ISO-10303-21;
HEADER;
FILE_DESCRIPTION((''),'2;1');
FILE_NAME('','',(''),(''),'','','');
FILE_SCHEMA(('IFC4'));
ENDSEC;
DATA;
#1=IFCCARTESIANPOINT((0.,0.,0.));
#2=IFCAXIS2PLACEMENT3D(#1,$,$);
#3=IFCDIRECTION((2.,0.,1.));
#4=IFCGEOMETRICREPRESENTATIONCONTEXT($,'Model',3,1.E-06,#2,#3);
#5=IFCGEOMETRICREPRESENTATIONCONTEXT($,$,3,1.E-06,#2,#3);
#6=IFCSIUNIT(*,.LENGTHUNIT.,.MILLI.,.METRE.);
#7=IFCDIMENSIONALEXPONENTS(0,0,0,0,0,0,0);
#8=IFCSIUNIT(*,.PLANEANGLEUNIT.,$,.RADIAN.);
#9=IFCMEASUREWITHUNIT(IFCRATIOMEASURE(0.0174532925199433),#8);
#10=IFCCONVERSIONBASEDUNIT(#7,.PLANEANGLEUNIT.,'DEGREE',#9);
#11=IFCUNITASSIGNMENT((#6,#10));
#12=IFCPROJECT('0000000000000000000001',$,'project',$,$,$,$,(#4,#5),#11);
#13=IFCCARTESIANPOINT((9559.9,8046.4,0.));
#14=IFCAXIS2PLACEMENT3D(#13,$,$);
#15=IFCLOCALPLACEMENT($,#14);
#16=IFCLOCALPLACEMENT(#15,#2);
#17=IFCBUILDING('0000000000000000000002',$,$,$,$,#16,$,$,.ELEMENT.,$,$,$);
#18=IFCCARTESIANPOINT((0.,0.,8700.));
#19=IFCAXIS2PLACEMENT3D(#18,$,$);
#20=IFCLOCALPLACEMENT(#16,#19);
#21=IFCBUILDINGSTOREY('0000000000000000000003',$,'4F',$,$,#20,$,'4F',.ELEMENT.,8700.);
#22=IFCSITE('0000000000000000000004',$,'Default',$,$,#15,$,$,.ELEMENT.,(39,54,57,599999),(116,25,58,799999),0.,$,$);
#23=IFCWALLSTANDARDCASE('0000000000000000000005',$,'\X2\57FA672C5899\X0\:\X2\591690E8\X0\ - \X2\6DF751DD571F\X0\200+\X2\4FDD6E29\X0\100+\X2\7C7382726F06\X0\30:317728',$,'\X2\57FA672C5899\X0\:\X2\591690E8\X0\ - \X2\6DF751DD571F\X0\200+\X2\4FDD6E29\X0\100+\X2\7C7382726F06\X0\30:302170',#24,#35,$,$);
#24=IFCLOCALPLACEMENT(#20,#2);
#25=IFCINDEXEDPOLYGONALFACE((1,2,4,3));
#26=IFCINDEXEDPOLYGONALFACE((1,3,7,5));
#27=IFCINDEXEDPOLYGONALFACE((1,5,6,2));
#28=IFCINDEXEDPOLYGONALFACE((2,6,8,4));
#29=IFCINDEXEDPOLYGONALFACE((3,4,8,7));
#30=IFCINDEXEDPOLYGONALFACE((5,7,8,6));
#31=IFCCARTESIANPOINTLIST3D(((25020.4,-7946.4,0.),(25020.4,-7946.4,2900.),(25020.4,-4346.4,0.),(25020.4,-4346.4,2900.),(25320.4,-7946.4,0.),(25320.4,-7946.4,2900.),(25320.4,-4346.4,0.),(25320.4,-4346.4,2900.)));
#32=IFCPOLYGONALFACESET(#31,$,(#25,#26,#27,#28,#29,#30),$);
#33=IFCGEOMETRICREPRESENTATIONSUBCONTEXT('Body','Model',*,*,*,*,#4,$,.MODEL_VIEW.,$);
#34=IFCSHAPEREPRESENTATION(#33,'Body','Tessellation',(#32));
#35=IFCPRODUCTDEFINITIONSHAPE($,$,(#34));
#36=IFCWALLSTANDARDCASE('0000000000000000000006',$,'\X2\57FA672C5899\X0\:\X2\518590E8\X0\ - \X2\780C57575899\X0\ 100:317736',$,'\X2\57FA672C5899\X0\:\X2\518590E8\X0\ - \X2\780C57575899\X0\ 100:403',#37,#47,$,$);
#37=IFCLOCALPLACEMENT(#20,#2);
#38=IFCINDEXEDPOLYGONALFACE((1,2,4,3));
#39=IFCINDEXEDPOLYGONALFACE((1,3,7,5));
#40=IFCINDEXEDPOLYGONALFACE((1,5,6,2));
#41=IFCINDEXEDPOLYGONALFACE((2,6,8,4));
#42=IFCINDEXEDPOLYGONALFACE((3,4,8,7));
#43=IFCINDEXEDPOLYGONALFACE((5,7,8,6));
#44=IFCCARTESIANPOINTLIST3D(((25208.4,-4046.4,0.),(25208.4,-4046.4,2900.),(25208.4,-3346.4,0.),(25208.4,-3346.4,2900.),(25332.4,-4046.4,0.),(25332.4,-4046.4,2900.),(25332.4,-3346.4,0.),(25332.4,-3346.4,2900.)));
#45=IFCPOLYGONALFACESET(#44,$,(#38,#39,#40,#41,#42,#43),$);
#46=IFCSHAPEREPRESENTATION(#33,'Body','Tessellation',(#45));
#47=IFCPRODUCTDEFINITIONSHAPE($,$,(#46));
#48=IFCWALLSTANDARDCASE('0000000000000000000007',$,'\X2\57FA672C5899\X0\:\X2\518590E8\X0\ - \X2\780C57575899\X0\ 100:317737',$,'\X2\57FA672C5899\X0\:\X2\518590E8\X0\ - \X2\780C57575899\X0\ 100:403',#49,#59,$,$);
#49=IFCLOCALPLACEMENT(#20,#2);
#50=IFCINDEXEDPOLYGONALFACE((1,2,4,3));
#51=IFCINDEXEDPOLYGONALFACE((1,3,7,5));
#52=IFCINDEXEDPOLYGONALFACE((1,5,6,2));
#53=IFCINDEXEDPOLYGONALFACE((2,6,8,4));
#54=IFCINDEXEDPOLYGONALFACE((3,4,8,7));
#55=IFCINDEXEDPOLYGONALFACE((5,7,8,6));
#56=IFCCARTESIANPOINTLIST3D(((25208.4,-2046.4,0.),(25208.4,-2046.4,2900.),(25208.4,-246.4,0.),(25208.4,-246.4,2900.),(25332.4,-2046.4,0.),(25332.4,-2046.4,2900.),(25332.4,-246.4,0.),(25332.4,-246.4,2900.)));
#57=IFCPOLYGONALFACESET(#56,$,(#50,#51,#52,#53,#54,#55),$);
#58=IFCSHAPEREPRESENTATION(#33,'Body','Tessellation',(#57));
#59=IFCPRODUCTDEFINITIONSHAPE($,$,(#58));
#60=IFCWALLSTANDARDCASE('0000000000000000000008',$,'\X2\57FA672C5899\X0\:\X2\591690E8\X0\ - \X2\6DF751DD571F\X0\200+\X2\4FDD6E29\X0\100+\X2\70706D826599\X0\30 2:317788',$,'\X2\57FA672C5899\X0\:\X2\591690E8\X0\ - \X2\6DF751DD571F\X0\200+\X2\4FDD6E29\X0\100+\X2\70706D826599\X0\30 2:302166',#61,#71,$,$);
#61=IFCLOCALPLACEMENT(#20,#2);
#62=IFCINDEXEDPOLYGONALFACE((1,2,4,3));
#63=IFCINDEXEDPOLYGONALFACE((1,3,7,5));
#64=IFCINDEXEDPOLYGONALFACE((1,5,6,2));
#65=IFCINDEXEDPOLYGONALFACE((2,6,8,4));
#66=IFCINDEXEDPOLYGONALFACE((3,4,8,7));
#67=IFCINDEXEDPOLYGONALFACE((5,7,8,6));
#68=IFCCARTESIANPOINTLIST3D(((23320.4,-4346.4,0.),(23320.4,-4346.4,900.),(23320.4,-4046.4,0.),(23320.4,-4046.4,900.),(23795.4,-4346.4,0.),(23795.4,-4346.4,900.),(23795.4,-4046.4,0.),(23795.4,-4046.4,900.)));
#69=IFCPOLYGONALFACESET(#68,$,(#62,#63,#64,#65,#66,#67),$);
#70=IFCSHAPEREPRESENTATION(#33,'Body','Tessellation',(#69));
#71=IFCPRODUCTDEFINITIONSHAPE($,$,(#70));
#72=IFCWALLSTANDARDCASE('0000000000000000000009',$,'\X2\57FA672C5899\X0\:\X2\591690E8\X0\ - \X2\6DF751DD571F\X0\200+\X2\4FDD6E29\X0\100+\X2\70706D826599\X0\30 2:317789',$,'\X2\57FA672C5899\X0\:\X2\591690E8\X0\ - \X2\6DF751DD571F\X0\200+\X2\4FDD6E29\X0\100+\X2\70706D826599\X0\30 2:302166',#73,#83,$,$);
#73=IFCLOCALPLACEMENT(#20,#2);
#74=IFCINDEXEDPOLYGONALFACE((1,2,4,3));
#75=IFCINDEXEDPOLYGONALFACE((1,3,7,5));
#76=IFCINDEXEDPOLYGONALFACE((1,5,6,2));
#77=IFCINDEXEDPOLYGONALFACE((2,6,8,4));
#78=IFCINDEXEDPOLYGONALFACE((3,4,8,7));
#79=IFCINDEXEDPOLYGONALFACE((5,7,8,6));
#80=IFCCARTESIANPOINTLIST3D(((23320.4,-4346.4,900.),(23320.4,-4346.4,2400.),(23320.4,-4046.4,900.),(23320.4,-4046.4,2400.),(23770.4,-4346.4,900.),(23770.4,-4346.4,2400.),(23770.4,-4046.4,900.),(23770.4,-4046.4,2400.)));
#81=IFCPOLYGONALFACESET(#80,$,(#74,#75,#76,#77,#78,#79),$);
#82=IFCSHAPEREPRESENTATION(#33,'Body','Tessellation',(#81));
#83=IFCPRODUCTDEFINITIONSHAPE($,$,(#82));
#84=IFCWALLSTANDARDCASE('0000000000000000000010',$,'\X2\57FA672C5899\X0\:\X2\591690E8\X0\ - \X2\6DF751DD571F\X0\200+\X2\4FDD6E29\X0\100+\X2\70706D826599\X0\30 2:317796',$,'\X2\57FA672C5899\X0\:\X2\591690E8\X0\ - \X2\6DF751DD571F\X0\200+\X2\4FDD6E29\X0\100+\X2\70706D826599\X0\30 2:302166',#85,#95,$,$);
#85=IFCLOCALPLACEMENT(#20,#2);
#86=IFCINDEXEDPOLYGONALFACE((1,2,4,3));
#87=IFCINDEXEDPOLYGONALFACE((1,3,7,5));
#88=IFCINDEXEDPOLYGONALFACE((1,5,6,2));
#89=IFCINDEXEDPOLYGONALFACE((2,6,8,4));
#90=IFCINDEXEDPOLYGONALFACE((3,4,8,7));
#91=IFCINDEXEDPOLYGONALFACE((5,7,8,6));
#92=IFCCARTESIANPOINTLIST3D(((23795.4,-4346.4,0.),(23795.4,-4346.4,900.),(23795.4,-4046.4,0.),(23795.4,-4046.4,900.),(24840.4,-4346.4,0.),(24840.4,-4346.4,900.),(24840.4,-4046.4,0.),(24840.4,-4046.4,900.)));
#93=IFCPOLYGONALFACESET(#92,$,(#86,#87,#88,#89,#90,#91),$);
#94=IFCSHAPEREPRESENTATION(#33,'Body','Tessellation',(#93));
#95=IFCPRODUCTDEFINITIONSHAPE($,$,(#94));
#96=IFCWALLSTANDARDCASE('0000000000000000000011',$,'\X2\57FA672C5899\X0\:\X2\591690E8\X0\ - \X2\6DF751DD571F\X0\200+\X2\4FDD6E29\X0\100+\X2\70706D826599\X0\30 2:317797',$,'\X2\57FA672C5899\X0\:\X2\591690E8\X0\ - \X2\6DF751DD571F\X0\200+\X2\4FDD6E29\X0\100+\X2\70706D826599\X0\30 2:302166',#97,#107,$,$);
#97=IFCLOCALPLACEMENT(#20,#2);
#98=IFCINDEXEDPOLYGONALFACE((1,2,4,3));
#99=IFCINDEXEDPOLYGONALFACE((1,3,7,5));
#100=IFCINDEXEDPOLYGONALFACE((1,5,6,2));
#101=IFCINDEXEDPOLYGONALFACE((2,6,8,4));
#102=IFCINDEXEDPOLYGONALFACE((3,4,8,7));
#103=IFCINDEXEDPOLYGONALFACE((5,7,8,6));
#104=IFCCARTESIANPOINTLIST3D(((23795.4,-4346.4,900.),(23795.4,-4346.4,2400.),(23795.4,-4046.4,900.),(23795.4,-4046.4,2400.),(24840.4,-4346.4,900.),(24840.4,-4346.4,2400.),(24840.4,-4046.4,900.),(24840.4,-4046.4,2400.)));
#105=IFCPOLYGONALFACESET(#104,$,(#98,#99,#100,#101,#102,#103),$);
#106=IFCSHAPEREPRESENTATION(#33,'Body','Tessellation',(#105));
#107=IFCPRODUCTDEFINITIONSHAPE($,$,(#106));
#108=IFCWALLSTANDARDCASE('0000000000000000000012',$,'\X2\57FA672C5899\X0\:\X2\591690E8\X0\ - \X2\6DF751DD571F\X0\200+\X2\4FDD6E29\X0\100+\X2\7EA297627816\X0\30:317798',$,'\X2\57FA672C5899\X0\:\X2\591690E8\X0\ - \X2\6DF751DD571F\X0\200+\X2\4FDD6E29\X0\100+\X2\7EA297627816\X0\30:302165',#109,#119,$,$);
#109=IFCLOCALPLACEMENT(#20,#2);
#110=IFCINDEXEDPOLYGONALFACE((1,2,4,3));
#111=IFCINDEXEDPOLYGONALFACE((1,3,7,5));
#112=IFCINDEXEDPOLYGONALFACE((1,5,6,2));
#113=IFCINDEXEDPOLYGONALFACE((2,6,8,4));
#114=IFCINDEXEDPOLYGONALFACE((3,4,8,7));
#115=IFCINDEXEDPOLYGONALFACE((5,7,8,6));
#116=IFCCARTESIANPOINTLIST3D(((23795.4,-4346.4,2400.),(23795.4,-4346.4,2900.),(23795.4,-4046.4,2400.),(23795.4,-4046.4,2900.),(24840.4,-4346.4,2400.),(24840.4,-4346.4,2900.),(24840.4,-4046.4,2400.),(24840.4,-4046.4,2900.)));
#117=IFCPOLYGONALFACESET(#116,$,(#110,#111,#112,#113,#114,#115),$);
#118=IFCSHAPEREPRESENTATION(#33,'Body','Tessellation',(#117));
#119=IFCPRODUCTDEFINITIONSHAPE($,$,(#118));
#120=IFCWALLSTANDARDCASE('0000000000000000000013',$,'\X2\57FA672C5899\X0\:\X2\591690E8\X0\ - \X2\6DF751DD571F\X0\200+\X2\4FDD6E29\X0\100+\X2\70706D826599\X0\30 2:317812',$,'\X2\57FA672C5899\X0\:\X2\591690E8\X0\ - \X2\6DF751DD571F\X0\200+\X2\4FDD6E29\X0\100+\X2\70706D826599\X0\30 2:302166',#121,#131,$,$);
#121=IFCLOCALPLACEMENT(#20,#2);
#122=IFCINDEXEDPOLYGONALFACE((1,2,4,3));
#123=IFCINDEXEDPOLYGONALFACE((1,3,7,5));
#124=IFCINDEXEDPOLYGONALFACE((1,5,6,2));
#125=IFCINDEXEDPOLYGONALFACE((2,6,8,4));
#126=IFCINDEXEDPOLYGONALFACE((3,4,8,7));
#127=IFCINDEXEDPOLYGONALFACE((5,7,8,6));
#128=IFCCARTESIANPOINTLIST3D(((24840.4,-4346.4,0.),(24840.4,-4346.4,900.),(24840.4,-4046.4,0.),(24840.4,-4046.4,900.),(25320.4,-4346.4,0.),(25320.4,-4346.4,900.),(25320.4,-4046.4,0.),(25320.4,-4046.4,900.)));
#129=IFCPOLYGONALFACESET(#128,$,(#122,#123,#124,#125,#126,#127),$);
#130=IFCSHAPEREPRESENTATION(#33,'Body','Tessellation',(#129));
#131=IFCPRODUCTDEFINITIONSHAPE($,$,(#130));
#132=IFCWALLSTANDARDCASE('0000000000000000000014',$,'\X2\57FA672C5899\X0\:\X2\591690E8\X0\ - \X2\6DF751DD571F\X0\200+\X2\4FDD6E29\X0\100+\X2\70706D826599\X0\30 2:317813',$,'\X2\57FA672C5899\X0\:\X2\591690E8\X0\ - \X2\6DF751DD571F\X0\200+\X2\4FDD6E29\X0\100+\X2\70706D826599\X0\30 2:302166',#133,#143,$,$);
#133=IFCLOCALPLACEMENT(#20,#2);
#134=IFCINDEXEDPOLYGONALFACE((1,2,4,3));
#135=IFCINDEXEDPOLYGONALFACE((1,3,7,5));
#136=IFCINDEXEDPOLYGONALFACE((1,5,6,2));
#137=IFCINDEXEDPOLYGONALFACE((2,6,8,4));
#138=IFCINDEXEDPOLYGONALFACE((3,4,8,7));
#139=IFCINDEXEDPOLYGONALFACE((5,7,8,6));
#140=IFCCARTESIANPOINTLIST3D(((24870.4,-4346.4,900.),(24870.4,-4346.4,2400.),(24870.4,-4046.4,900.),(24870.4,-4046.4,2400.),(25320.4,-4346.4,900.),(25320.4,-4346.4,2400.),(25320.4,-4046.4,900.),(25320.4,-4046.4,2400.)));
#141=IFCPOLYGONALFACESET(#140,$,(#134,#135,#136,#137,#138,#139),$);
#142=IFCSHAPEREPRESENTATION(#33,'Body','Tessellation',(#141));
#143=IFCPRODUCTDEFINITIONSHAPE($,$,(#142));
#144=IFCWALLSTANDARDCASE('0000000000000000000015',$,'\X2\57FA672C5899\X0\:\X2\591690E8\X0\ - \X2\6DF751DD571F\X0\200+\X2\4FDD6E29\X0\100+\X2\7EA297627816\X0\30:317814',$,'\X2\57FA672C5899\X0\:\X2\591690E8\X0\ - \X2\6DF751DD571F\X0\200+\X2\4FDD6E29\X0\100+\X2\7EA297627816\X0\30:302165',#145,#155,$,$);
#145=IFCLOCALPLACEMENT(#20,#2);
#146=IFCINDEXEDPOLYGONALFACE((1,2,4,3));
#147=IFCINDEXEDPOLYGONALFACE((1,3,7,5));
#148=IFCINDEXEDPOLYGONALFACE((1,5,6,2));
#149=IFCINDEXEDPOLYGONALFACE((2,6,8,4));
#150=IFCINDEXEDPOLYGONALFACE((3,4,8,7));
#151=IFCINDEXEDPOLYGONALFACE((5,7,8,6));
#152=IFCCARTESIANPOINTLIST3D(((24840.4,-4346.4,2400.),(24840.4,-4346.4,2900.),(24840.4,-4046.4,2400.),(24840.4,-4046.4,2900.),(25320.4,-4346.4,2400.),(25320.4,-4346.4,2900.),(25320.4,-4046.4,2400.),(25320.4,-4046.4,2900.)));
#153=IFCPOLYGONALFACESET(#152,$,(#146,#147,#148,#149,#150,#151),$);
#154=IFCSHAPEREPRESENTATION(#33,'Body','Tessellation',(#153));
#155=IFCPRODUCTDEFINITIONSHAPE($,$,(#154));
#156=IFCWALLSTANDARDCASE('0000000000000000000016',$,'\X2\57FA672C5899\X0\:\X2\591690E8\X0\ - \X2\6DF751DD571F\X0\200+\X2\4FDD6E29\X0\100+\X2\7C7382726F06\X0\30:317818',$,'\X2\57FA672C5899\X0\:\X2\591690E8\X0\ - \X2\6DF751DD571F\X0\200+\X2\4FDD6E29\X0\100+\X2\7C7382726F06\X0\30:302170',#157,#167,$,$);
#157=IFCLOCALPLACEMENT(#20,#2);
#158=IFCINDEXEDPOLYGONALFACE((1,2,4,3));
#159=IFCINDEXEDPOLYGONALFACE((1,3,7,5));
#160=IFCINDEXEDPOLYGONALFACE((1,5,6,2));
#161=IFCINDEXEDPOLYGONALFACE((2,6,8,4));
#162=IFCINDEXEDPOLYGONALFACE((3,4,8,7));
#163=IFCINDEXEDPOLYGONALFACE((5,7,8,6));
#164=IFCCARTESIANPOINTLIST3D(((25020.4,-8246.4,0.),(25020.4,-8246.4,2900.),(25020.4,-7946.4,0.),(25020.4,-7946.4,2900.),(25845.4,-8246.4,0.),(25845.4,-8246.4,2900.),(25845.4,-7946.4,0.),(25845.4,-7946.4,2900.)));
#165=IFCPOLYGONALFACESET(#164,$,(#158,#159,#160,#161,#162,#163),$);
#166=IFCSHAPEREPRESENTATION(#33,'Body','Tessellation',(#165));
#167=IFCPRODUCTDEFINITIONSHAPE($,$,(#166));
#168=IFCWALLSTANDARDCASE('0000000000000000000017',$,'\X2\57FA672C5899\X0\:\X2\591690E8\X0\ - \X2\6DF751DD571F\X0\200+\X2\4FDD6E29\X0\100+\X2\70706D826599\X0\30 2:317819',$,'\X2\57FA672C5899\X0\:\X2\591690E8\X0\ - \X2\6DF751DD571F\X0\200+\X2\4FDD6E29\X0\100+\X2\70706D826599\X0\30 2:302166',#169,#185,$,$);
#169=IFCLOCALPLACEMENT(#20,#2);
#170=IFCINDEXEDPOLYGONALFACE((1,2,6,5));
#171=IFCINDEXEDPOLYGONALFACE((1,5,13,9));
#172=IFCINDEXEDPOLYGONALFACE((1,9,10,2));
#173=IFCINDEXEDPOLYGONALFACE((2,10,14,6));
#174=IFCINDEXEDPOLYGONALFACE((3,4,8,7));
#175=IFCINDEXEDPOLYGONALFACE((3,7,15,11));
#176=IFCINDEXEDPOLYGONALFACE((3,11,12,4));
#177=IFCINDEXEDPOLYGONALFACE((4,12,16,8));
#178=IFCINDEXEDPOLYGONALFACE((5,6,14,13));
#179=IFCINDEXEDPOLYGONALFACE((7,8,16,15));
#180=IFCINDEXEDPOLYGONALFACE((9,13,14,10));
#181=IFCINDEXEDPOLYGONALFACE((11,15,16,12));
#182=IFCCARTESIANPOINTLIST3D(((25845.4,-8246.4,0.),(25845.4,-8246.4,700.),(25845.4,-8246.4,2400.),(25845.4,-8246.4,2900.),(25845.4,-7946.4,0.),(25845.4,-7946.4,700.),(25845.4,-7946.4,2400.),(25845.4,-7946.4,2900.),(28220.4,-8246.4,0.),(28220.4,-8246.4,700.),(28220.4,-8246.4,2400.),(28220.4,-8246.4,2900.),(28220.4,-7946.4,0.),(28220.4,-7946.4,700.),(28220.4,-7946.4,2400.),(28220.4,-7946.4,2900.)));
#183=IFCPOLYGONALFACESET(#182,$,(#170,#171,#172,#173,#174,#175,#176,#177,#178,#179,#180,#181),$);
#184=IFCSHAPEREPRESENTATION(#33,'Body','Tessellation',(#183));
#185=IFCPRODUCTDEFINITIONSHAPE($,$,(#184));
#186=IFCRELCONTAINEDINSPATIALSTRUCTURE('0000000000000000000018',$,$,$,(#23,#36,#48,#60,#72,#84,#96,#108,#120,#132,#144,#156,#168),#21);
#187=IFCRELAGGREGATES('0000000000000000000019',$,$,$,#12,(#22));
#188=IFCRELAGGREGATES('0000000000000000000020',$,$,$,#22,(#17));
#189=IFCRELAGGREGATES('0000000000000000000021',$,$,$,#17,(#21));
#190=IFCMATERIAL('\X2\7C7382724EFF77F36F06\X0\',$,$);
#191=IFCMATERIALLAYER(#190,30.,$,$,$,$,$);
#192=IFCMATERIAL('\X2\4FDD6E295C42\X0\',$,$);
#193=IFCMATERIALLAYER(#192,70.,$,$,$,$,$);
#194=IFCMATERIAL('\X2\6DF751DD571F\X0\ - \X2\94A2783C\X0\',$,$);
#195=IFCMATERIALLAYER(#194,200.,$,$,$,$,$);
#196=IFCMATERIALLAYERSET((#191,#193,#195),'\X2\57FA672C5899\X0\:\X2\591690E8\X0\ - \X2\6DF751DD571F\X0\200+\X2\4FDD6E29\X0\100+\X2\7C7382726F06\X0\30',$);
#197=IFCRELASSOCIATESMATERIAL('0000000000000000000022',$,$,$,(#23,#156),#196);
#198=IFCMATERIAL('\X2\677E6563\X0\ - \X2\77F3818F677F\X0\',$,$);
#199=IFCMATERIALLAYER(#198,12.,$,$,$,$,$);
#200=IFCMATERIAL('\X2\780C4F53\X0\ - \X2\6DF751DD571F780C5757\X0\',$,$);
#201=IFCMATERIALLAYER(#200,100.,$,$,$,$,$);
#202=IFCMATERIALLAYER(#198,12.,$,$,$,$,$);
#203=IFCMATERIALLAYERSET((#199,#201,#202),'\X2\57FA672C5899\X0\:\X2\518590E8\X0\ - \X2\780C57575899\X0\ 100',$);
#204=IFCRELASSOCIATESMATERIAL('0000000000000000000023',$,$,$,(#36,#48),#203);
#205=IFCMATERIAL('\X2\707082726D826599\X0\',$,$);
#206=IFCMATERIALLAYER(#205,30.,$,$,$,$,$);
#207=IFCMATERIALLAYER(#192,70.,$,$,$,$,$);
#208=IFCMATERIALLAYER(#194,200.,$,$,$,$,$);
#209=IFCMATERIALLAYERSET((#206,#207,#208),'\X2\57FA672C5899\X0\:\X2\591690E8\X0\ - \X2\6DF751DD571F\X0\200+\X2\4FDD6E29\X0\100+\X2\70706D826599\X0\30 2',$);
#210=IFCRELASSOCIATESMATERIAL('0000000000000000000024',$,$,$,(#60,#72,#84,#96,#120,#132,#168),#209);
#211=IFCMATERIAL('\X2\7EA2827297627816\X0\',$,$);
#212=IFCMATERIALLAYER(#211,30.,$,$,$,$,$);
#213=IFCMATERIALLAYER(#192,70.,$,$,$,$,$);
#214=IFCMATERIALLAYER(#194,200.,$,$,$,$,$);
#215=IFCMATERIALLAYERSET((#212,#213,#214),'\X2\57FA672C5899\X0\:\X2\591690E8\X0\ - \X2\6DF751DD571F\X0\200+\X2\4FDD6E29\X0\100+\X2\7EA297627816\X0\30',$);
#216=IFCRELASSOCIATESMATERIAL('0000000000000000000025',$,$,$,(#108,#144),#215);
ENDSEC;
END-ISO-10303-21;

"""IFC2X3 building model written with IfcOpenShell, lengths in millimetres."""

from ifc_helpers import new_model, entity, si_unit, converted_unit, direction, frame, frame_2d, origin, place, context, subcontext, project, spatial, rectangle, extrude, material, layer, layer_set, layer_usage, element, save


model = new_model("IFC2X3")

# Units and contexts
model_context = context("Model", 3, precision=1e-06, world=origin(), true_north=direction((2.0, 0.0, 1.0)))
context_of_model = context(None, 3, precision=1e-06, world=origin(), true_north=direction((2.0, 0.0, 1.0)))
body_context = subcontext(model_context, "Body", "Model", "MODEL_VIEW")
ifc_project = project(units=[si_unit("LENGTHUNIT", "METRE", prefix="MILLI"), converted_unit("PLANEANGLEUNIT", "DEGREE", entity("IfcRatioMeasure", 0.0174532925199433), si_unit("PLANEANGLEUNIT", "RADIAN"), dimensions=[0, 0, 0, 0, 0, 0, 0])], contexts=[model_context, context_of_model])

# Site, building, storey
site_placement = place(None, frame((9559.9, 8046.4, 0.0)))
site = spatial("IfcSite", under=ifc_project, at=site_placement, Name="Default", CompositionType="ELEMENT", RefLatitude=(39, 54, 57, 599999), RefLongitude=(116, 25, 58, 799999), RefElevation=0.0)
building_placement = place(site_placement, origin())
building = spatial("IfcBuilding", under=site, at=building_placement, CompositionType="ELEMENT")
storey_placement = place(building_placement, frame((0.0, 0.0, 8700.0)))
storey = spatial("IfcBuildingStorey", under=building, at=storey_placement, Name="4F", LongName="4F", CompositionType="ELEMENT", Elevation=8700.0)

# Shared definitions
ifc_material_1 = material(Name="混凝土 - 钢砼")
ifc_material_2 = material(Name="红色面砖")
ifc_layer_1 = layer(ifc_material_2, 30.0)
ifc_material_3 = material(Name="保温层")
ifc_layer_2 = layer(ifc_material_3, 70.0)
ifc_layer_3 = layer(ifc_material_1, 200.0)
ifc_layer_set_1 = layer_set([ifc_layer_1, ifc_layer_2, ifc_layer_3], Name="基本墙:外部 - 混凝土200+保温100+红面砖30")

# Shared definitions
ifc_material_4 = material(Name="米色仿石漆")
ifc_layer_4 = layer(ifc_material_4, 30.0)
ifc_layer_5 = layer(ifc_material_3, 70.0)
ifc_layer_6 = layer(ifc_material_1, 200.0)
ifc_layer_set_2 = layer_set([ifc_layer_4, ifc_layer_5, ifc_layer_6], Name="基本墙:外部 - 混凝土200+保温100+米色漆30")

# Shared definitions
ifc_material_5 = material(Name="灰色涂料")
ifc_layer_7 = layer(ifc_material_5, 30.0)
ifc_layer_8 = layer(ifc_material_3, 70.0)
ifc_layer_9 = layer(ifc_material_1, 200.0)
ifc_layer_set_3 = layer_set([ifc_layer_7, ifc_layer_8, ifc_layer_9], Name="基本墙:外部 - 混凝土200+保温100+灰涂料30 2")
ifc_material_6 = material(Name="松散 - 石膏板")
ifc_layer_10 = layer(ifc_material_6, 12.0)
ifc_material_7 = material(Name="砌体 - 混凝土砌块")
ifc_layer_11 = layer(ifc_material_7, 100.0)
ifc_layer_12 = layer(ifc_material_6, 12.0)
ifc_layer_set_4 = layer_set([ifc_layer_10, ifc_layer_11, ifc_layer_12], Name="基本墙:内部 - 砌块墙 100")

# Walls
ifc_layer_usage_1 = layer_usage(ifc_layer_set_2, "AXIS2", "POSITIVE", -150.0)
wall_1_placement = place(storey_placement, frame((25170.4, -4346.4, 0.0), z_axis=(0.0, 0.0, 1.0), x_axis=(0.0, -1.0, 0.0)))
element("IfcWallStandardCase", 1, at=wall_1_placement, inside=storey, material=ifc_layer_usage_1, Name="基本墙:外部 - 混凝土200+保温100+米色漆30:317728", ObjectType="基本墙:外部 - 混凝土200+保温100+米色漆30:302170", context=body_context, shape_type="SweptSolid", body=[
    extrude(rectangle(XDim=3600.0, YDim=300.0, at=frame_2d((1800.0, 0.0), x_axis=(-1.0, 0.0))), origin(), (0.0, 0.0, 1.0), 2900.0),
])
ifc_layer_usage_2 = layer_usage(ifc_layer_set_4, "AXIS2", "POSITIVE", -62.0)
wall_2_placement = place(storey_placement, frame((25270.4, -4046.4, 0.0), z_axis=(0.0, 0.0, 1.0), x_axis=(0.0, 1.0, 0.0)))
element("IfcWallStandardCase", 2, at=wall_2_placement, inside=storey, material=ifc_layer_usage_2, Name="基本墙:内部 - 砌块墙 100:317736", ObjectType="基本墙:内部 - 砌块墙 100:403", context=body_context, shape_type="SweptSolid", body=[
    extrude(rectangle(XDim=700.0, YDim=124.0, at=frame_2d((350.0, 0.0), x_axis=(-1.0, 0.0))), origin(), (0.0, 0.0, 1.0), 2900.0),
])
ifc_layer_usage_3 = layer_usage(ifc_layer_set_4, "AXIS2", "POSITIVE", -62.0)
wall_3_placement = place(storey_placement, frame((25270.4, -246.4, 0.0), z_axis=(0.0, 0.0, 1.0), x_axis=(0.0, -1.0, 0.0)))
element("IfcWallStandardCase", 3, at=wall_3_placement, inside=storey, material=ifc_layer_usage_3, Name="基本墙:内部 - 砌块墙 100:317737", ObjectType="基本墙:内部 - 砌块墙 100:403", context=body_context, shape_type="SweptSolid", body=[
    extrude(rectangle(XDim=1800.0, YDim=124.0, at=frame_2d((900.0, 0.0), x_axis=(-1.0, 0.0))), origin(), (0.0, 0.0, 1.0), 2900.0),
])
ifc_layer_usage_4 = layer_usage(ifc_layer_set_3, "AXIS2", "POSITIVE", -150.0)
wall_4_placement = place(storey_placement, frame((23320.4, -4196.4, 0.0)))
element("IfcWallStandardCase", 4, at=wall_4_placement, inside=storey, material=ifc_layer_usage_4, Name="基本墙:外部 - 混凝土200+保温100+灰涂料30 2:317788", ObjectType="基本墙:外部 - 混凝土200+保温100+灰涂料30 2:302166", context=body_context, shape_type="SweptSolid", body=[
    extrude(rectangle(XDim=475.0, YDim=300.0, at=frame_2d((237.5, 0.0), x_axis=(-1.0, 0.0))), origin(), (0.0, 0.0, 1.0), 900.0),
])
ifc_layer_usage_5 = layer_usage(ifc_layer_set_3, "AXIS2", "POSITIVE", -150.0)
wall_5_placement = place(storey_placement, frame((23320.4, -4196.4, 900.0)))
element("IfcWallStandardCase", 5, at=wall_5_placement, inside=storey, material=ifc_layer_usage_5, Name="基本墙:外部 - 混凝土200+保温100+灰涂料30 2:317789", ObjectType="基本墙:外部 - 混凝土200+保温100+灰涂料30 2:302166", context=body_context, shape_type="SweptSolid", body=[
    extrude(rectangle(XDim=450.0, YDim=300.0, at=frame_2d((225.0, 0.0), x_axis=(-1.0, 0.0))), origin(), (0.0, 0.0, 1.0), 1500.0),
])

# Walls
ifc_layer_usage_6 = layer_usage(ifc_layer_set_3, "AXIS2", "POSITIVE", -150.0)
wall_6_placement = place(storey_placement, frame((23795.4, -4196.4, 0.0)))
element("IfcWallStandardCase", 6, at=wall_6_placement, inside=storey, material=ifc_layer_usage_6, Name="基本墙:外部 - 混凝土200+保温100+灰涂料30 2:317796", ObjectType="基本墙:外部 - 混凝土200+保温100+灰涂料30 2:302166", context=body_context, shape_type="SweptSolid", body=[
    extrude(rectangle(XDim=1045.0, YDim=300.0, at=frame_2d((522.5, 0.0), x_axis=(-1.0, 0.0))), origin(), (0.0, 0.0, 1.0), 900.0),
])
ifc_layer_usage_7 = layer_usage(ifc_layer_set_3, "AXIS2", "POSITIVE", -150.0)
wall_7_placement = place(storey_placement, frame((23795.4, -4196.4, 900.0)))
element("IfcWallStandardCase", 7, at=wall_7_placement, inside=storey, material=ifc_layer_usage_7, Name="基本墙:外部 - 混凝土200+保温100+灰涂料30 2:317797", ObjectType="基本墙:外部 - 混凝土200+保温100+灰涂料30 2:302166", context=body_context, shape_type="SweptSolid", body=[
    extrude(rectangle(XDim=1045.0, YDim=300.0, at=frame_2d((522.5, 0.0), x_axis=(-1.0, 0.0))), origin(), (0.0, 0.0, 1.0), 1500.0),
])
ifc_layer_usage_8 = layer_usage(ifc_layer_set_1, "AXIS2", "POSITIVE", -150.0)
wall_8_placement = place(storey_placement, frame((23795.4, -4196.4, 2400.0)))
element("IfcWallStandardCase", 8, at=wall_8_placement, inside=storey, material=ifc_layer_usage_8, Name="基本墙:外部 - 混凝土200+保温100+红面砖30:317798", ObjectType="基本墙:外部 - 混凝土200+保温100+红面砖30:302165", context=body_context, shape_type="SweptSolid", body=[
    extrude(rectangle(XDim=1045.0, YDim=300.0, at=frame_2d((522.5, 0.0), x_axis=(-1.0, 0.0))), origin(), (0.0, 0.0, 1.0), 500.0),
])
ifc_layer_usage_9 = layer_usage(ifc_layer_set_3, "AXIS2", "POSITIVE", -150.0)
wall_9_placement = place(storey_placement, frame((24840.4, -4196.4, 0.0)))
element("IfcWallStandardCase", 9, at=wall_9_placement, inside=storey, material=ifc_layer_usage_9, Name="基本墙:外部 - 混凝土200+保温100+灰涂料30 2:317812", ObjectType="基本墙:外部 - 混凝土200+保温100+灰涂料30 2:302166", context=body_context, shape_type="SweptSolid", body=[
    extrude(rectangle(XDim=480.0, YDim=300.0, at=frame_2d((240.0, 0.0), x_axis=(-1.0, 0.0))), origin(), (0.0, 0.0, 1.0), 900.0),
])
ifc_layer_usage_10 = layer_usage(ifc_layer_set_3, "AXIS2", "POSITIVE", -150.0)
wall_10_placement = place(storey_placement, frame((24870.4, -4196.4, 900.0)))
element("IfcWallStandardCase", 10, at=wall_10_placement, inside=storey, material=ifc_layer_usage_10, Name="基本墙:外部 - 混凝土200+保温100+灰涂料30 2:317813", ObjectType="基本墙:外部 - 混凝土200+保温100+灰涂料30 2:302166", context=body_context, shape_type="SweptSolid", body=[
    extrude(rectangle(XDim=450.0, YDim=300.0, at=frame_2d((225.0, 0.0), x_axis=(-1.0, 0.0))), origin(), (0.0, 0.0, 1.0), 1500.0),
])
ifc_layer_usage_11 = layer_usage(ifc_layer_set_1, "AXIS2", "POSITIVE", -150.0)
wall_11_placement = place(storey_placement, frame((24840.4, -4196.4, 2400.0)))
element("IfcWallStandardCase", 11, at=wall_11_placement, inside=storey, material=ifc_layer_usage_11, Name="基本墙:外部 - 混凝土200+保温100+红面砖30:317814", ObjectType="基本墙:外部 - 混凝土200+保温100+红面砖30:302165", context=body_context, shape_type="SweptSolid", body=[
    extrude(rectangle(XDim=480.0, YDim=300.0, at=frame_2d((240.0, 0.0), x_axis=(-1.0, 0.0))), origin(), (0.0, 0.0, 1.0), 500.0),
])
ifc_layer_usage_12 = layer_usage(ifc_layer_set_2, "AXIS2", "POSITIVE", -150.0)
wall_12_placement = place(storey_placement, frame((25020.4, -8096.4, 0.0)))
element("IfcWallStandardCase", 12, at=wall_12_placement, inside=storey, material=ifc_layer_usage_12, Name="基本墙:外部 - 混凝土200+保温100+米色漆30:317818", ObjectType="基本墙:外部 - 混凝土200+保温100+米色漆30:302170", context=body_context, shape_type="SweptSolid", body=[
    extrude(rectangle(XDim=825.0, YDim=300.0, at=frame_2d((412.5, 0.0), x_axis=(-1.0, 0.0))), origin(), (0.0, 0.0, 1.0), 2900.0),
])

# Wall, opening
ifc_layer_usage_13 = layer_usage(ifc_layer_set_3, "AXIS2", "POSITIVE", -150.0)
wall_13_placement = place(storey_placement, frame((25845.4, -8096.4, 0.0)))
wall_13 = element("IfcWallStandardCase", 13, at=wall_13_placement, inside=storey, material=ifc_layer_usage_13, Name="基本墙:外部 - 混凝土200+保温100+灰涂料30 2:317819", ObjectType="基本墙:外部 - 混凝土200+保温100+灰涂料30 2:302166", context=body_context, shape_type="SweptSolid", body=[
    extrude(rectangle(XDim=2375.0, YDim=300.0, at=frame_2d((1187.5, 0.0), x_axis=(-1.0, 0.0))), origin(), (0.0, 0.0, 1.0), 2900.0),
])
opening_1_placement = place(wall_13_placement, frame((-25.0, -150.0, 700.0)))
element("IfcOpeningElement", 14, at=opening_1_placement, cuts=wall_13, ObjectType="Opening", context=body_context, shape_type="SweptSolid", body=[
    extrude(rectangle(XDim=1700.0, YDim=2400.0, at=frame_2d((850.0, 1200.0), x_axis=(1.0, 0.0))), frame((0.0, 0.0, 0.0), z_axis=(0.0, 1.0, 0.0), x_axis=(0.0, 0.0, 1.0)), (0.0, 0.0, 1.0), 300.0),
])

save(model, "model.ifc")
